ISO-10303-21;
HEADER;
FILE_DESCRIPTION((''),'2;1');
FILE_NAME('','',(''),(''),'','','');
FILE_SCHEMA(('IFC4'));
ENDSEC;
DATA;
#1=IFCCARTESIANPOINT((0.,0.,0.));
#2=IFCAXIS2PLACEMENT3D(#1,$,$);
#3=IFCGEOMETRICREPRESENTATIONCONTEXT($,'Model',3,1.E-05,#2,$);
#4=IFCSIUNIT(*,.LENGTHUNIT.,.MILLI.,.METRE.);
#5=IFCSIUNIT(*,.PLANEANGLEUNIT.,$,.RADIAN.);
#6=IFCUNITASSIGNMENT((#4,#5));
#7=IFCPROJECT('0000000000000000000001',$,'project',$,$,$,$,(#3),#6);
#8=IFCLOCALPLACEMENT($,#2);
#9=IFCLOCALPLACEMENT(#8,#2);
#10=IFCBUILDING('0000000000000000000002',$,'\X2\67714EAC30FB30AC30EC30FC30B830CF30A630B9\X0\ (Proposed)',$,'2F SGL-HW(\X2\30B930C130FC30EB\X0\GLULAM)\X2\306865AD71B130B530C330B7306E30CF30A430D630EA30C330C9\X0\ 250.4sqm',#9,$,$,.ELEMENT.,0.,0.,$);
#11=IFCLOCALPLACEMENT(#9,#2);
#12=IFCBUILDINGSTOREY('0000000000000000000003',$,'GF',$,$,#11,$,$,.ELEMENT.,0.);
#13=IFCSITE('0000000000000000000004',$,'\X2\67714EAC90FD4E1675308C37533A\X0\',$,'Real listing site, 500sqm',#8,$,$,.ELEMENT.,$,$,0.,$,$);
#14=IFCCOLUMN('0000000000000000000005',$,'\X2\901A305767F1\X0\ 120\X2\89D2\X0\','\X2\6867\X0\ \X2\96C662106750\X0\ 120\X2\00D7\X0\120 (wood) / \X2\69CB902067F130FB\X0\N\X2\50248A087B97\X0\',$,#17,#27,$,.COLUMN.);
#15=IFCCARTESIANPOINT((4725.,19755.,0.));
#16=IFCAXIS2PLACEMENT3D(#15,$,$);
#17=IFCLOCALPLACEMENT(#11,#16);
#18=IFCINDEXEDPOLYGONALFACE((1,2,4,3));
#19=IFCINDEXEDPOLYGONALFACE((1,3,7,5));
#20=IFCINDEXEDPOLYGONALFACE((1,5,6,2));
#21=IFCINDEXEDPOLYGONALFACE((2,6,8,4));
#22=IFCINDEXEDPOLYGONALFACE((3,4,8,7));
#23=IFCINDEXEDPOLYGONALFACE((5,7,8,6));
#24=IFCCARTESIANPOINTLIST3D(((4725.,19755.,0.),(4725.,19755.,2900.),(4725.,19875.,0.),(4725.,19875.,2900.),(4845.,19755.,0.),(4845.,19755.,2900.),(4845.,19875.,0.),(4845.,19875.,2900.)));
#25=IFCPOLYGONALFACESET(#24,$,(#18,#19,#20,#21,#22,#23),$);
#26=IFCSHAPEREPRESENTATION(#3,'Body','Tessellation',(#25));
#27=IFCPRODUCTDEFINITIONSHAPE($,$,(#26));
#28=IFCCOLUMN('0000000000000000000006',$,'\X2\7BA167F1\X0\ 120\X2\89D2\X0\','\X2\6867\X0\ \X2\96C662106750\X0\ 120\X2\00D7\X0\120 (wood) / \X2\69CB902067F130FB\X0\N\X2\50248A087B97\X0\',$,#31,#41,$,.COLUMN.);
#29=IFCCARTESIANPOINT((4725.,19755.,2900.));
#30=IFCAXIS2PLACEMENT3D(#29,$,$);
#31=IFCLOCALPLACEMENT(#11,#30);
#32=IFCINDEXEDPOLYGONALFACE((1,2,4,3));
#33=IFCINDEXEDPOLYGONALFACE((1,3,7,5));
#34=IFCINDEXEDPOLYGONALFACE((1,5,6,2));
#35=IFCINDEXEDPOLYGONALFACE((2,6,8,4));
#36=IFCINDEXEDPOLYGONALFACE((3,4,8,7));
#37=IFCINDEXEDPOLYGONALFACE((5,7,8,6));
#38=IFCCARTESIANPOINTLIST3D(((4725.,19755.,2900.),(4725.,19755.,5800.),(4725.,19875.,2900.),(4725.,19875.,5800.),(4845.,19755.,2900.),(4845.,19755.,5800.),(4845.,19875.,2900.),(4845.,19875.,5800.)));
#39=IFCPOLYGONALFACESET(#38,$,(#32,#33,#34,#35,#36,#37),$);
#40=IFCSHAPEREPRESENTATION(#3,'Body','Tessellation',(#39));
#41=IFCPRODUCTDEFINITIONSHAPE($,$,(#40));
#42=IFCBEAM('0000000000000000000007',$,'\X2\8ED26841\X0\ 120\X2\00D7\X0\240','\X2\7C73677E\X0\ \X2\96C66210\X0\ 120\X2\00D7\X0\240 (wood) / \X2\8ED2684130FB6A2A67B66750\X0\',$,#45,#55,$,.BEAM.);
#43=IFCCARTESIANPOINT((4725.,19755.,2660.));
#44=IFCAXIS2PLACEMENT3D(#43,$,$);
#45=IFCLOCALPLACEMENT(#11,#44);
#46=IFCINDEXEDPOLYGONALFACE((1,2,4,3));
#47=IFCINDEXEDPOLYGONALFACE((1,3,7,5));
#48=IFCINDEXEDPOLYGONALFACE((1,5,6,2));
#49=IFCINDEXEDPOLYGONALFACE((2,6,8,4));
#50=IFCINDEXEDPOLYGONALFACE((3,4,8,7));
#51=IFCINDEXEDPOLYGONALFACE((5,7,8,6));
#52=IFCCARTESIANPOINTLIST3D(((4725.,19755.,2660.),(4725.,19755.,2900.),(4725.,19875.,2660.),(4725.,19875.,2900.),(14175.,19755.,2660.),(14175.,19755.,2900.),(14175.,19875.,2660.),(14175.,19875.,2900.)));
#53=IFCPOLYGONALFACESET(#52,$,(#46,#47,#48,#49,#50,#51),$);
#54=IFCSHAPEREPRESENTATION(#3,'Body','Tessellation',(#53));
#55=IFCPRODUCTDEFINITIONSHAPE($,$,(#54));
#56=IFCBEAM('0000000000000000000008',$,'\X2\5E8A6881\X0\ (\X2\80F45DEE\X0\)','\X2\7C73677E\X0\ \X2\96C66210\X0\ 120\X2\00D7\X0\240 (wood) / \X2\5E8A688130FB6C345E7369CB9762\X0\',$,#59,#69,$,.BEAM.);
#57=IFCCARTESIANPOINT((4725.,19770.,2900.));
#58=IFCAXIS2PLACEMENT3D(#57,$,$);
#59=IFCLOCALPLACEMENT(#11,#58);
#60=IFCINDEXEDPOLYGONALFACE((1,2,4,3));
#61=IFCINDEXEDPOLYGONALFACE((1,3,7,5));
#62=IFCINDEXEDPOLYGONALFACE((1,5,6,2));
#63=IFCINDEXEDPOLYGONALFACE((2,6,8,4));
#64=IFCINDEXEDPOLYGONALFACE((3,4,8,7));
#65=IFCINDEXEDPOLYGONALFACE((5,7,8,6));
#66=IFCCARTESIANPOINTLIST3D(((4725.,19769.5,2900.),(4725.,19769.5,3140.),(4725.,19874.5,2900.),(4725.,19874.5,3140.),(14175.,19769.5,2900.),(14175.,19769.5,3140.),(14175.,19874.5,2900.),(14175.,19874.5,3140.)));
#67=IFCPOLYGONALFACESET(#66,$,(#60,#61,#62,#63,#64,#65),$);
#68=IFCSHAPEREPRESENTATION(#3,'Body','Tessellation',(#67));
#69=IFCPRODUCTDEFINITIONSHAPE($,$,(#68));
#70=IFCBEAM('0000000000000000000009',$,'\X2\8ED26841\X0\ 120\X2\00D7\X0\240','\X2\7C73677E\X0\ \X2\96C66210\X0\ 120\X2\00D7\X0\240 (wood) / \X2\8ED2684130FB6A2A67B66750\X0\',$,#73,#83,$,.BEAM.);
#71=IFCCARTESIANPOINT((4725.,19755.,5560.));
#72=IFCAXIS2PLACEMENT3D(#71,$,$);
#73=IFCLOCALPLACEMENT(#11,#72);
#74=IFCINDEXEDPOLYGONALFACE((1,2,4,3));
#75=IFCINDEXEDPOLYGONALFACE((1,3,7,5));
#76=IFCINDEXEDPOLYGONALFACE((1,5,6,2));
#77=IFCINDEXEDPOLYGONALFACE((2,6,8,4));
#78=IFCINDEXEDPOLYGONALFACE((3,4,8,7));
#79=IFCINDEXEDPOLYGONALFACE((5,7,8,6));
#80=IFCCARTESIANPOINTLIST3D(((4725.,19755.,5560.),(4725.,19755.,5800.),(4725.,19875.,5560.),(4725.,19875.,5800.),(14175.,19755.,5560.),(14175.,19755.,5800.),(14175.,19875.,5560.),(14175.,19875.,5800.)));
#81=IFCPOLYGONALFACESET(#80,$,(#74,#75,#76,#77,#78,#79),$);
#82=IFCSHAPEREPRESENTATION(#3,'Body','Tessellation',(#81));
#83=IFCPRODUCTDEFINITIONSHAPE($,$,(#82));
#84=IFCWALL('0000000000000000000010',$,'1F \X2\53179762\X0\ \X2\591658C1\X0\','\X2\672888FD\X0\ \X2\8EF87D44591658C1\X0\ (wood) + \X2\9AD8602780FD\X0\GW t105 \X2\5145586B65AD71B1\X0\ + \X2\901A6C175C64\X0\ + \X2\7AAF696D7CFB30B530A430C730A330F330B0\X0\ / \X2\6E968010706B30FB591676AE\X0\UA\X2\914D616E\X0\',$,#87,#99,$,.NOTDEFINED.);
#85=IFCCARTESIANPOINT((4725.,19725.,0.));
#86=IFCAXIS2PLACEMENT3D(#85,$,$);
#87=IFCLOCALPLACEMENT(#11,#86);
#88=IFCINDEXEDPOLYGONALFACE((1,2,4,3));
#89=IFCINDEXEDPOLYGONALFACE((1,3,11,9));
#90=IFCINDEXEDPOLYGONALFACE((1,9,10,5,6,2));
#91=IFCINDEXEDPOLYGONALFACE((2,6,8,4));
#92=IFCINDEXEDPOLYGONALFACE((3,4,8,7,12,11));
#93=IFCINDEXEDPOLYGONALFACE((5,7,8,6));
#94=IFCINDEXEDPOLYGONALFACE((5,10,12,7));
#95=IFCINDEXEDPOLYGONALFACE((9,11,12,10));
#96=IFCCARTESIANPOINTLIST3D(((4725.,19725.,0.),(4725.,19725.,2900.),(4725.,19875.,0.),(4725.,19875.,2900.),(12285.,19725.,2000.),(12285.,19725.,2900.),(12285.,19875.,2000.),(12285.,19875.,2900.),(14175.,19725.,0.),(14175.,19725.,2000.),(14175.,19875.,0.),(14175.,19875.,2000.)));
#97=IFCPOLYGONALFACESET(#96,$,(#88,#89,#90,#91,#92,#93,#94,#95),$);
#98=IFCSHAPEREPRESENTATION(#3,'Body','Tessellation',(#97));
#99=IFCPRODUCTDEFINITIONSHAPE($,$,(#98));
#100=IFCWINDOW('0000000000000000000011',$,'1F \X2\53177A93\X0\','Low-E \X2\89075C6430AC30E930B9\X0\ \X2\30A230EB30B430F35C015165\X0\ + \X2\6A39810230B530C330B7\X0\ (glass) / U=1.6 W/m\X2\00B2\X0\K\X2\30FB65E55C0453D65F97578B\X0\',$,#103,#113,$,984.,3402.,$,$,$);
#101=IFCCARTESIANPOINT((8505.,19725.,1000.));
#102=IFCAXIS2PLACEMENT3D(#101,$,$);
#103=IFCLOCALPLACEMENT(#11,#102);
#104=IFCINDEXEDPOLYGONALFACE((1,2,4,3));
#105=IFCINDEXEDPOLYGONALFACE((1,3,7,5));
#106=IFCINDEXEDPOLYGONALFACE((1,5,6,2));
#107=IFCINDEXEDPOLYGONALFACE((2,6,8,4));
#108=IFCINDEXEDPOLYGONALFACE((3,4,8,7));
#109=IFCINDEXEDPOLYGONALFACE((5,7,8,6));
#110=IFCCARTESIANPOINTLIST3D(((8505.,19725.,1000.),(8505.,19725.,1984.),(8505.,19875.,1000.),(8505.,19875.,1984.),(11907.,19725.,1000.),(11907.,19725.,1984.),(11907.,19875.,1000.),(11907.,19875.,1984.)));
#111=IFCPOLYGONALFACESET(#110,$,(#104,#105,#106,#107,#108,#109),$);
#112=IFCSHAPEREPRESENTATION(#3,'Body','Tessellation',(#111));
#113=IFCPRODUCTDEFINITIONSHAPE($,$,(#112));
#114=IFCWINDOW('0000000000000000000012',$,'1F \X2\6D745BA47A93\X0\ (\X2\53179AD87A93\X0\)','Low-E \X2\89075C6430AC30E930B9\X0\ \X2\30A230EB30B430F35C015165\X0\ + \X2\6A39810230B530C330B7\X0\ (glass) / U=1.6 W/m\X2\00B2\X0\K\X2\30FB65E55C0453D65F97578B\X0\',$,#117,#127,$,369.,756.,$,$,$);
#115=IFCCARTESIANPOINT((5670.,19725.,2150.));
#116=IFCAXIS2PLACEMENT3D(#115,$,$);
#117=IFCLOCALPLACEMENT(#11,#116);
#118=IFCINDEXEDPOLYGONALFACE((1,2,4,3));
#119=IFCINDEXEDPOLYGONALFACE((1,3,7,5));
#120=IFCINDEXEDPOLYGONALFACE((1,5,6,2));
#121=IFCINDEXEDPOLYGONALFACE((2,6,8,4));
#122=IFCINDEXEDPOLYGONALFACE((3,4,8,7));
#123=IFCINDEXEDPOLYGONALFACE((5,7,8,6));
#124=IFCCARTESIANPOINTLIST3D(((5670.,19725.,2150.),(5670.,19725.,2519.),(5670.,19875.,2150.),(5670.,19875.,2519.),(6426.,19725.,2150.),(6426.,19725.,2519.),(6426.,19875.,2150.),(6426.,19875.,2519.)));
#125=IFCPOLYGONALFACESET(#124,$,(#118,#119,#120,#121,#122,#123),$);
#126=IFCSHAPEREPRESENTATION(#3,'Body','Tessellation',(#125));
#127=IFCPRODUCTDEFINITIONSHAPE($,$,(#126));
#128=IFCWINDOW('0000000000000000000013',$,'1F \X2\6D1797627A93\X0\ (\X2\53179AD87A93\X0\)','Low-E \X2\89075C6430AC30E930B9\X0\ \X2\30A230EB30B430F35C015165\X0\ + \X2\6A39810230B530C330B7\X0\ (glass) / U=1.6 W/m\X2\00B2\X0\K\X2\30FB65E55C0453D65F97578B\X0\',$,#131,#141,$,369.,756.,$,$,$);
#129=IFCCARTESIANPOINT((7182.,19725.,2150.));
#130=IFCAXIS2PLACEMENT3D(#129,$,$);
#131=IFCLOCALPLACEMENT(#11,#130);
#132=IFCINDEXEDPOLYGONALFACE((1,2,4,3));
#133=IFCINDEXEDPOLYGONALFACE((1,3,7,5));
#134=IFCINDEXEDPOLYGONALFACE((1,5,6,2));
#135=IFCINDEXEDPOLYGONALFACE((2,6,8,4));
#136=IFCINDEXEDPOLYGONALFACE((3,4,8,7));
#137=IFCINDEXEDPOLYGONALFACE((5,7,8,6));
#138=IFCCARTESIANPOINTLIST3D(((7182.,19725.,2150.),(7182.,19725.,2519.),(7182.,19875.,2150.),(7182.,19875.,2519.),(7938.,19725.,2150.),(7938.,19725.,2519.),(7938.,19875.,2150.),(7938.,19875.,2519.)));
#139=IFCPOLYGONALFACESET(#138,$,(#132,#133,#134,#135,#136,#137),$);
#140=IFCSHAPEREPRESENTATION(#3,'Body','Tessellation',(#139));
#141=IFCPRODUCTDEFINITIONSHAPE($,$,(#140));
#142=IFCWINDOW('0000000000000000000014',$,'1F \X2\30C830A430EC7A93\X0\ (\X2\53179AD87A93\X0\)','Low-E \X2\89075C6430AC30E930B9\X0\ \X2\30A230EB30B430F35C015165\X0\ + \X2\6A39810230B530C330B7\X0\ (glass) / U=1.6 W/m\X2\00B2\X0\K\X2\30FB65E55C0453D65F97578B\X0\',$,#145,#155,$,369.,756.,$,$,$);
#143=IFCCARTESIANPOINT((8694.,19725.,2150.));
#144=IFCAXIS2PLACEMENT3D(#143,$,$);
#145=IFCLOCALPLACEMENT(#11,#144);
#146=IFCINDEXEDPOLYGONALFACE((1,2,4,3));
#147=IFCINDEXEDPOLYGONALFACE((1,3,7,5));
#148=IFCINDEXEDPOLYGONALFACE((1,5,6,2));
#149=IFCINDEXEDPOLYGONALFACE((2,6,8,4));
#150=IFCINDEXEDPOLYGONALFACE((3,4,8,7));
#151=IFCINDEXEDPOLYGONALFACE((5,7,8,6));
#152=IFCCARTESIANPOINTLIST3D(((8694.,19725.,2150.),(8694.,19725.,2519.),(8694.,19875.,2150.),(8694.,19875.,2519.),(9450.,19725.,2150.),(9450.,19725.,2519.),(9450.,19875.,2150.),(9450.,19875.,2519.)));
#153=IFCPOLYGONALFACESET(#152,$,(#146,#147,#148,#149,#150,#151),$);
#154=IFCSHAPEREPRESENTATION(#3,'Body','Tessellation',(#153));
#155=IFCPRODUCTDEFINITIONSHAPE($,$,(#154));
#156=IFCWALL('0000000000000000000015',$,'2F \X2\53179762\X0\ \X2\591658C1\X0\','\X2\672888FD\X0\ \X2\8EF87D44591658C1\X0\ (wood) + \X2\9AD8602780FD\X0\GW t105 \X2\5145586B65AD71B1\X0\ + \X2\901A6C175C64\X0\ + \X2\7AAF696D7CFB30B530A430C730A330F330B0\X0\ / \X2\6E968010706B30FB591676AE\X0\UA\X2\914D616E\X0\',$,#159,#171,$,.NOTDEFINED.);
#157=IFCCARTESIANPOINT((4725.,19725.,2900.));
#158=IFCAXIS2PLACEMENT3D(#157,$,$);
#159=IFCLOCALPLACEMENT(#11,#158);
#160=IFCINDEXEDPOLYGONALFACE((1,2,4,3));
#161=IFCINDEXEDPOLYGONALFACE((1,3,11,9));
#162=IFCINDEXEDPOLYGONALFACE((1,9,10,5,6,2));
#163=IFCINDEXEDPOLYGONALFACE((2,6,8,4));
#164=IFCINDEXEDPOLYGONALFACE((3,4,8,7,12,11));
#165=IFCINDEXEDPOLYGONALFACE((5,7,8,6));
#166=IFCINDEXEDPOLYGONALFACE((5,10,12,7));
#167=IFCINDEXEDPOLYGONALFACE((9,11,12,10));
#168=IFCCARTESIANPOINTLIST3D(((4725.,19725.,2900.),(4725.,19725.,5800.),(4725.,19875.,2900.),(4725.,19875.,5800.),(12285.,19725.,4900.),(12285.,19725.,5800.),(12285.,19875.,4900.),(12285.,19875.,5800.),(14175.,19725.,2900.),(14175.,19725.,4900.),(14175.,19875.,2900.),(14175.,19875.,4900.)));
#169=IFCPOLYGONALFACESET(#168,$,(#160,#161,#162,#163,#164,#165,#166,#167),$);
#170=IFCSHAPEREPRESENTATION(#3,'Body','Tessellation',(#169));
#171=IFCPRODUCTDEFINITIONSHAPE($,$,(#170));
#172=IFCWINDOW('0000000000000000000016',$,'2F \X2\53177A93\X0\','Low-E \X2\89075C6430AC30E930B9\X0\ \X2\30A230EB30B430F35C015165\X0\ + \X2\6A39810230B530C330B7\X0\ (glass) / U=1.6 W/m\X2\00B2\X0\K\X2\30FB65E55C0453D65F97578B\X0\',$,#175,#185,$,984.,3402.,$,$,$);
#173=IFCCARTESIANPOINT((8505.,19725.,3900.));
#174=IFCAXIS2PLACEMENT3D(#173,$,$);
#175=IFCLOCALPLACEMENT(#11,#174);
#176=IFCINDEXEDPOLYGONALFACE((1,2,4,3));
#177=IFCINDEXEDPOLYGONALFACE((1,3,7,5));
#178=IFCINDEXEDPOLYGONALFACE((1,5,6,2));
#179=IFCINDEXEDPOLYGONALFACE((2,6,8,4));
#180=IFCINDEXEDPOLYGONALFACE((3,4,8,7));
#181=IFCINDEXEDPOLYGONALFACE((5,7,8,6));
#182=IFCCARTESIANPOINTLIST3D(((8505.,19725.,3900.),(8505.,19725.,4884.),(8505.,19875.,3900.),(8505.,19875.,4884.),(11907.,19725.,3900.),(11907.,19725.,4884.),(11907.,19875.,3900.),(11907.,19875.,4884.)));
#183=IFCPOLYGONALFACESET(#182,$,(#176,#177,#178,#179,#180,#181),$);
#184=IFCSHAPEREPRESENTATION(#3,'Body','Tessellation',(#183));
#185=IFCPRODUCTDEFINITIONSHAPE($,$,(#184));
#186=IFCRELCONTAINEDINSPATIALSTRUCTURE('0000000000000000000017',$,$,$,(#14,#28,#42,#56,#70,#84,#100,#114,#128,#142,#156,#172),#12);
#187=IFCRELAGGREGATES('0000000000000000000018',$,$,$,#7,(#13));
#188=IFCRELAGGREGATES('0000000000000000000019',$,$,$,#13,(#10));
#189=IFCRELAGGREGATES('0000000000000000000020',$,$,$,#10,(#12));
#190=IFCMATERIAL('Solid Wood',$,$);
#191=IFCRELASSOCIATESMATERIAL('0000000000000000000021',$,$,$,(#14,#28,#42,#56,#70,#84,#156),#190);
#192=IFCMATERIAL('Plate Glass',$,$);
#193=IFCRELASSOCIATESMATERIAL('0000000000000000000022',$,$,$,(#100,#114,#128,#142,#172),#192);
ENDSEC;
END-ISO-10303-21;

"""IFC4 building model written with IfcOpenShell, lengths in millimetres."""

from ifc_helpers import new_model, si_unit, frame, frame_2d, origin, place, context, project, spatial, rectangle, extrude, material, element, fill, save


model = new_model("IFC4")

# Units and contexts
model_context = context("Model", 3, precision=1e-05, world=origin())
ifc_project = project(units=[si_unit("LENGTHUNIT", "METRE", prefix="MILLI"), si_unit("PLANEANGLEUNIT", "RADIAN")], contexts=[model_context])

# Site, building, storey
site_placement = place(None, origin())
site = spatial("IfcSite", under=ifc_project, at=site_placement, Name="東京都世田谷区", ObjectType="Real listing site, 500sqm", CompositionType="ELEMENT", RefElevation=0.0)
building_placement = place(site_placement, origin())
building = spatial("IfcBuilding", under=site, at=building_placement, Name="東京・ガレージハウス (Proposed)", ObjectType="2F SGL-HW(スチールGLULAM)と断熱サッシのハイブリッド 250.4sqm", CompositionType="ELEMENT", ElevationOfRefHeight=0.0, ElevationOfTerrain=0.0)
storey_placement = place(building_placement, origin())
storey = spatial("IfcBuildingStorey", under=building, at=storey_placement, Name="GF", CompositionType="ELEMENT", Elevation=0.0)

# Columns
ifc_material_1 = material(Name="Solid Wood")
column_1_placement = place(storey_placement, frame((4725.0, 19755.0, 0.0)))
element("IfcColumn", 1, at=column_1_placement, inside=storey, material=ifc_material_1, Name="通し柱 120角", Description="桧 集成材 120×120 (wood) / 構造柱・N値計算", PredefinedType="COLUMN", context=model_context, shape_type="SweptSolid", body=[
    extrude(rectangle(XDim=120.0, YDim=120.0, at=frame_2d((60.0, 60.0))), frame((4725.0, 19755.0, 0.0)), (0.0, 0.0, 1.0), 2900.0),
])
column_2_placement = place(storey_placement, frame((4725.0, 19755.0, 2900.0)))
element("IfcColumn", 2, at=column_2_placement, inside=storey, material=ifc_material_1, Name="管柱 120角", Description="桧 集成材 120×120 (wood) / 構造柱・N値計算", PredefinedType="COLUMN", context=model_context, shape_type="SweptSolid", body=[
    extrude(rectangle(XDim=120.0, YDim=120.0, at=frame_2d((60.0, 60.0))), frame((4725.0, 19755.0, 2900.0)), (0.0, 0.0, 1.0), 2900.0),
])

# Beams
beam_1_placement = place(storey_placement, frame((4725.0, 19755.0, 2660.0)))
element("IfcBeam", 3, at=beam_1_placement, inside=storey, material=ifc_material_1, Name="軒桁 120×240", Description="米松 集成 120×240 (wood) / 軒桁・横架材", PredefinedType="BEAM", context=model_context, shape_type="SweptSolid", body=[
    extrude(rectangle(XDim=9450.0, YDim=120.0, at=frame_2d((4725.0, 60.0))), frame((4725.0, 19755.0, 2660.0)), (0.0, 0.0, 1.0), 240.0),
])
beam_2_placement = place(storey_placement, frame((4725.0, 19770.0, 2900.0)))
element("IfcBeam", 4, at=beam_2_placement, inside=storey, material=ifc_material_1, Name="床梁 (胴差)", Description="米松 集成 120×240 (wood) / 床梁・水平構面", PredefinedType="BEAM", context=model_context, shape_type="SweptSolid", body=[
    extrude(rectangle(XDim=9450.0, YDim=105.0, at=frame_2d((4725.0, 52.0))), frame((4725.0, 19770.0, 2900.0)), (0.0, 0.0, 1.0), 240.0),
])
beam_3_placement = place(storey_placement, frame((4725.0, 19755.0, 5560.0)))
element("IfcBeam", 5, at=beam_3_placement, inside=storey, material=ifc_material_1, Name="軒桁 120×240", Description="米松 集成 120×240 (wood) / 軒桁・横架材", PredefinedType="BEAM", context=model_context, shape_type="SweptSolid", body=[
    extrude(rectangle(XDim=9450.0, YDim=120.0, at=frame_2d((4725.0, 60.0))), frame((4725.0, 19755.0, 5560.0)), (0.0, 0.0, 1.0), 240.0),
])

# Wall, openings, windows
wall_1_placement = place(storey_placement, frame((4725.0, 19725.0, 0.0)))
wall_1 = element("IfcWall", 6, at=wall_1_placement, inside=storey, material=ifc_material_1, Name="1F 北面 外壁", Description="木製 軸組外壁 (wood) + 高性能GW t105 充填断熱 + 通気層 + 窯業系サイディング / 準耐火・外皮UA配慮", PredefinedType="NOTDEFINED", context=model_context, shape_type="SweptSolid", body=[
    extrude(rectangle(XDim=9450.0, YDim=150.0, at=frame_2d((4725.0, 75.0))), frame((4725.0, 19725.0, 0.0)), (0.0, 0.0, 1.0), 2900.0),
])
opening_1_placement = place(storey_placement, frame((8505.0, 19725.0, 1000.0)))
opening_1 = element("IfcOpeningElement", 7, at=opening_1_placement, cuts=wall_1, PredefinedType="NOTDEFINED", context=model_context, shape_type="SweptSolid", body=[
    extrude(rectangle(XDim=3402.0, YDim=150.0, at=frame_2d((1701.0, 75.0))), frame((8505.0, 19725.0, 1000.0)), (0.0, 0.0, 1.0), 984.0),
])
opening_2_placement = place(storey_placement, frame((5670.0, 19725.0, 2150.0)))
opening_2 = element("IfcOpeningElement", 8, at=opening_2_placement, cuts=wall_1, PredefinedType="NOTDEFINED", context=model_context, shape_type="SweptSolid", body=[
    extrude(rectangle(XDim=756.0, YDim=150.0, at=frame_2d((378.0, 75.0))), frame((5670.0, 19725.0, 2150.0)), (0.0, 0.0, 1.0), 369.0),
])
opening_3_placement = place(storey_placement, frame((7182.0, 19725.0, 2150.0)))
opening_3 = element("IfcOpeningElement", 9, at=opening_3_placement, cuts=wall_1, PredefinedType="NOTDEFINED", context=model_context, shape_type="SweptSolid", body=[
    extrude(rectangle(XDim=756.0, YDim=150.0, at=frame_2d((378.0, 75.0))), frame((7182.0, 19725.0, 2150.0)), (0.0, 0.0, 1.0), 369.0),
])
opening_4_placement = place(storey_placement, frame((8694.0, 19725.0, 2150.0)))
opening_4 = element("IfcOpeningElement", 10, at=opening_4_placement, cuts=wall_1, PredefinedType="NOTDEFINED", context=model_context, shape_type="SweptSolid", body=[
    extrude(rectangle(XDim=756.0, YDim=150.0, at=frame_2d((378.0, 75.0))), frame((8694.0, 19725.0, 2150.0)), (0.0, 0.0, 1.0), 369.0),
])
ifc_material_2 = material(Name="Plate Glass")
window_1_placement = place(storey_placement, frame((8505.0, 19725.0, 1000.0)))
window_1 = element("IfcWindow", 11, at=window_1_placement, inside=storey, material=ifc_material_2, Name="1F 北窓", Description="Low-E 複層ガラス アルゴン封入 + 樹脂サッシ (glass) / U=1.6 W/m²K・日射取得型", OverallHeight=984.0, OverallWidth=3402.0, context=model_context, shape_type="SweptSolid", body=[
    extrude(rectangle(XDim=3402.0, YDim=150.0, at=frame_2d((1701.0, 75.0))), frame((8505.0, 19725.0, 1000.0)), (0.0, 0.0, 1.0), 984.0),
])
fill(opening_1, window_1)
window_2_placement = place(storey_placement, frame((5670.0, 19725.0, 2150.0)))
window_2 = element("IfcWindow", 12, at=window_2_placement, inside=storey, material=ifc_material_2, Name="1F 浴室窓 (北高窓)", Description="Low-E 複層ガラス アルゴン封入 + 樹脂サッシ (glass) / U=1.6 W/m²K・日射取得型", OverallHeight=369.0, OverallWidth=756.0, context=model_context, shape_type="SweptSolid", body=[
    extrude(rectangle(XDim=756.0, YDim=150.0, at=frame_2d((378.0, 75.0))), frame((5670.0, 19725.0, 2150.0)), (0.0, 0.0, 1.0), 369.0),
])
fill(opening_2, window_2)
window_3_placement = place(storey_placement, frame((7182.0, 19725.0, 2150.0)))
window_3 = element("IfcWindow", 13, at=window_3_placement, inside=storey, material=ifc_material_2, Name="1F 洗面窓 (北高窓)", Description="Low-E 複層ガラス アルゴン封入 + 樹脂サッシ (glass) / U=1.6 W/m²K・日射取得型", OverallHeight=369.0, OverallWidth=756.0, context=model_context, shape_type="SweptSolid", body=[
    extrude(rectangle(XDim=756.0, YDim=150.0, at=frame_2d((378.0, 75.0))), frame((7182.0, 19725.0, 2150.0)), (0.0, 0.0, 1.0), 369.0),
])
fill(opening_3, window_3)
window_4_placement = place(storey_placement, frame((8694.0, 19725.0, 2150.0)))
window_4 = element("IfcWindow", 14, at=window_4_placement, inside=storey, material=ifc_material_2, Name="1F トイレ窓 (北高窓)", Description="Low-E 複層ガラス アルゴン封入 + 樹脂サッシ (glass) / U=1.6 W/m²K・日射取得型", OverallHeight=369.0, OverallWidth=756.0, context=model_context, shape_type="SweptSolid", body=[
    extrude(rectangle(XDim=756.0, YDim=150.0, at=frame_2d((378.0, 75.0))), frame((8694.0, 19725.0, 2150.0)), (0.0, 0.0, 1.0), 369.0),
])
fill(opening_4, window_4)

# Wall, opening, window
wall_2_placement = place(storey_placement, frame((4725.0, 19725.0, 2900.0)))
wall_2 = element("IfcWall", 15, at=wall_2_placement, inside=storey, material=ifc_material_1, Name="2F 北面 外壁", Description="木製 軸組外壁 (wood) + 高性能GW t105 充填断熱 + 通気層 + 窯業系サイディング / 準耐火・外皮UA配慮", PredefinedType="NOTDEFINED", context=model_context, shape_type="SweptSolid", body=[
    extrude(rectangle(XDim=9450.0, YDim=150.0, at=frame_2d((4725.0, 75.0))), frame((4725.0, 19725.0, 2900.0)), (0.0, 0.0, 1.0), 2900.0),
])
opening_5_placement = place(storey_placement, frame((8505.0, 19725.0, 3900.0)))
opening_5 = element("IfcOpeningElement", 16, at=opening_5_placement, cuts=wall_2, PredefinedType="NOTDEFINED", context=model_context, shape_type="SweptSolid", body=[
    extrude(rectangle(XDim=3402.0, YDim=150.0, at=frame_2d((1701.0, 75.0))), frame((8505.0, 19725.0, 3900.0)), (0.0, 0.0, 1.0), 984.0),
])
window_5_placement = place(storey_placement, frame((8505.0, 19725.0, 3900.0)))
window_5 = element("IfcWindow", 17, at=window_5_placement, inside=storey, material=ifc_material_2, Name="2F 北窓", Description="Low-E 複層ガラス アルゴン封入 + 樹脂サッシ (glass) / U=1.6 W/m²K・日射取得型", OverallHeight=984.0, OverallWidth=3402.0, context=model_context, shape_type="SweptSolid", body=[
    extrude(rectangle(XDim=3402.0, YDim=150.0, at=frame_2d((1701.0, 75.0))), frame((8505.0, 19725.0, 3900.0)), (0.0, 0.0, 1.0), 984.0),
])
fill(opening_5, window_5)

save(model, "model.ifc")
